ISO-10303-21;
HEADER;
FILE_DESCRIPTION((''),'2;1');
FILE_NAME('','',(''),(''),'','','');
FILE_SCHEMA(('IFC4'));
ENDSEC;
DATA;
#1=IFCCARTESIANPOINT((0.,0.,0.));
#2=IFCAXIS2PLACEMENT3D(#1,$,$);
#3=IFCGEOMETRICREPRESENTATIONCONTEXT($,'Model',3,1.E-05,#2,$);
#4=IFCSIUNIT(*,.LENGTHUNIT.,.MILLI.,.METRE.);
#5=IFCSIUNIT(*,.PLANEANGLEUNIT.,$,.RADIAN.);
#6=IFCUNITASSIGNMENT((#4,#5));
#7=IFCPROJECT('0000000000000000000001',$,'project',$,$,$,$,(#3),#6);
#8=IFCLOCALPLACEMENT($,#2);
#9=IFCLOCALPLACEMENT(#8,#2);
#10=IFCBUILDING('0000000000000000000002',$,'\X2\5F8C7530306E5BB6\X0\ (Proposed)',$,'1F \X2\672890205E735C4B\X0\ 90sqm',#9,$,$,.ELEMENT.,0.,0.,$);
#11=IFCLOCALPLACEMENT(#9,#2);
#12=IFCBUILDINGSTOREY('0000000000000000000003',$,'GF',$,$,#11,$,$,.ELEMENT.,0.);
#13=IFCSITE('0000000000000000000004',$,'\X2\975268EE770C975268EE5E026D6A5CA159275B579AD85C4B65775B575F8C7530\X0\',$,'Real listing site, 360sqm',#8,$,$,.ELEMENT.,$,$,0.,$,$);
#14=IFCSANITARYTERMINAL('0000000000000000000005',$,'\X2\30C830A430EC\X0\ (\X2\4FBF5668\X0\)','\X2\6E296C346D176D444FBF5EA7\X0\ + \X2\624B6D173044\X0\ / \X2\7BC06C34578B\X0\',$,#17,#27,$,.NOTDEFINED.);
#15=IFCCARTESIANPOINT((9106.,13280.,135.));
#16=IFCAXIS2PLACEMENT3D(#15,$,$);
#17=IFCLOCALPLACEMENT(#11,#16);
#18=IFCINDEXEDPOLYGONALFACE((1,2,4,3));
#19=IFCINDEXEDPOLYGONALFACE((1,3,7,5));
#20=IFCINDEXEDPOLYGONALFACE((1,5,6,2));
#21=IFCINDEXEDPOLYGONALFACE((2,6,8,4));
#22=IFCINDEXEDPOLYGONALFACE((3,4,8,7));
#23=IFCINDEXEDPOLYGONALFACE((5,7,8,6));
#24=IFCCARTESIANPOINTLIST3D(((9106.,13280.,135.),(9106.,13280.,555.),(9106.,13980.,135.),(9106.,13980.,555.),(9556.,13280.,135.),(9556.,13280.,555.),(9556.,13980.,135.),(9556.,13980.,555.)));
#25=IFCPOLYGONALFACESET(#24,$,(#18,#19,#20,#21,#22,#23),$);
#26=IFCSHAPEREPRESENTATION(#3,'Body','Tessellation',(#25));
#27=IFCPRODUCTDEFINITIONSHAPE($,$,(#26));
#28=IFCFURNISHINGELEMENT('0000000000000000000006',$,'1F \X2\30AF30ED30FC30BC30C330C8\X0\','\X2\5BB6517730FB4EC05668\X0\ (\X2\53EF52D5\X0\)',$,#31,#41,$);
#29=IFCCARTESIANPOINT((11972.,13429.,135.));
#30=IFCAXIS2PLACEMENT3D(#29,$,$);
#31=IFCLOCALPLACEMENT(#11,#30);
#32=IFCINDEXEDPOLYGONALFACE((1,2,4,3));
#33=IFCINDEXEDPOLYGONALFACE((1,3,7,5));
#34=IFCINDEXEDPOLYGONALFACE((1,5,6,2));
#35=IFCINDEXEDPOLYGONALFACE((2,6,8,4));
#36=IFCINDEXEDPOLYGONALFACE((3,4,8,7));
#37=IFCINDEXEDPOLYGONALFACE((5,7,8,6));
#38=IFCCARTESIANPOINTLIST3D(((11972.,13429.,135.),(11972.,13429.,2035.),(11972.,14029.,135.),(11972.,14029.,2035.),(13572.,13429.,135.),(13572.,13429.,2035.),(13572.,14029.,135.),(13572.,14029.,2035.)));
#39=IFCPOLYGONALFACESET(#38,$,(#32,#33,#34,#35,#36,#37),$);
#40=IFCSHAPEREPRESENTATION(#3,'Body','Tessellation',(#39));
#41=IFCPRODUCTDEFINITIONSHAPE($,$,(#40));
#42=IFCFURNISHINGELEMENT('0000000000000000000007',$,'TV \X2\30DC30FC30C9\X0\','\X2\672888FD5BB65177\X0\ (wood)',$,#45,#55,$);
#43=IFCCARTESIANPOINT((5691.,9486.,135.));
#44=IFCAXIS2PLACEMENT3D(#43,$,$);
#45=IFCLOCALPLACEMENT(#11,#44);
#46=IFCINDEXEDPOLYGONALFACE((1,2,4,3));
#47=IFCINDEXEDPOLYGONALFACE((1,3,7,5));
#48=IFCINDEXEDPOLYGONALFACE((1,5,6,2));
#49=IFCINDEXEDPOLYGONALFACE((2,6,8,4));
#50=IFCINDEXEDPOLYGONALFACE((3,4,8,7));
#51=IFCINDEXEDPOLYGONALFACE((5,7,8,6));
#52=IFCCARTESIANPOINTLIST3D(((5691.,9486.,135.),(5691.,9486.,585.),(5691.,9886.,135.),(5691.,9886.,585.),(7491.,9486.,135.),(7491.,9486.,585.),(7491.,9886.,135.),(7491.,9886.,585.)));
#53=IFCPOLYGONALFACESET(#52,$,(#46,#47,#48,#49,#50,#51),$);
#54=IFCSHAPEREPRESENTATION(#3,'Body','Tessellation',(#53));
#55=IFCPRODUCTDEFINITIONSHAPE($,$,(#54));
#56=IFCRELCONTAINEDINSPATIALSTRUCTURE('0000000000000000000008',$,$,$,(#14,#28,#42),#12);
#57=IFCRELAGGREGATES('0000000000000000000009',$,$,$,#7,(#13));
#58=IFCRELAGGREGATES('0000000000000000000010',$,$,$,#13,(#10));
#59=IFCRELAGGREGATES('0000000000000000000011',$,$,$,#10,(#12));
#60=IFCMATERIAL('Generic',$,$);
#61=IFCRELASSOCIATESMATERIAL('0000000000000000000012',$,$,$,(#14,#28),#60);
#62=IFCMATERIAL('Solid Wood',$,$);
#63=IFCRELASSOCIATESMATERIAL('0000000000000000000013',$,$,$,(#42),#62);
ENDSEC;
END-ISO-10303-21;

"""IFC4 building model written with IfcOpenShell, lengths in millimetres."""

from ifc_helpers import new_model, si_unit, frame, frame_2d, origin, place, context, project, spatial, rectangle, extrude, material, element, save


model = new_model("IFC4")

# Units and contexts
model_context = context("Model", 3, precision=1e-05, world=origin())
ifc_project = project(units=[si_unit("LENGTHUNIT", "METRE", prefix="MILLI"), si_unit("PLANEANGLEUNIT", "RADIAN")], contexts=[model_context])

# Site, building, storey
site_placement = place(None, origin())
site = spatial("IfcSite", under=ifc_project, at=site_placement, Name="青森県青森市浪岡大字高屋敷字後田", ObjectType="Real listing site, 360sqm", CompositionType="ELEMENT", RefElevation=0.0)
building_placement = place(site_placement, origin())
building = spatial("IfcBuilding", under=site, at=building_placement, Name="後田の家 (Proposed)", ObjectType="1F 木造平屋 90sqm", CompositionType="ELEMENT", ElevationOfRefHeight=0.0, ElevationOfTerrain=0.0)
storey_placement = place(building_placement, origin())
storey = spatial("IfcBuildingStorey", under=building, at=storey_placement, Name="GF", CompositionType="ELEMENT", Elevation=0.0)

# Shared definitions
ifc_material_1 = material(Name="Solid Wood")

# Sanitary terminal
ifc_material_2 = material(Name="Generic")
sanitary_terminal_1_placement = place(storey_placement, frame((9106.0, 13280.0, 135.0)))
element("IfcSanitaryTerminal", 1, at=sanitary_terminal_1_placement, inside=storey, material=ifc_material_2, Name="トイレ (便器)", Description="温水洗浄便座 + 手洗い / 節水型", PredefinedType="NOTDEFINED", context=model_context, shape_type="SweptSolid", body=[
    extrude(rectangle(XDim=450.0, YDim=700.0, at=frame_2d((225.0, 350.0))), frame((9106.0, 13280.0, 135.0)), (0.0, 0.0, 1.0), 420.0),
])

# Furnishing elements
furnishing_1_placement = place(storey_placement, frame((11972.0, 13429.0, 135.0)))
element("IfcFurnishingElement", 2, at=furnishing_1_placement, inside=storey, material=ifc_material_2, Name="1F クローゼット", Description="家具・什器 (可動)", context=model_context, shape_type="SweptSolid", body=[
    extrude(rectangle(XDim=1600.0, YDim=600.0, at=frame_2d((800.0, 300.0))), frame((11972.0, 13429.0, 135.0)), (0.0, 0.0, 1.0), 1900.0),
])
furnishing_2_placement = place(storey_placement, frame((5691.0, 9486.0, 135.0)))
element("IfcFurnishingElement", 3, at=furnishing_2_placement, inside=storey, material=ifc_material_1, Name="TV ボード", Description="木製家具 (wood)", context=model_context, shape_type="SweptSolid", body=[
    extrude(rectangle(XDim=1800.0, YDim=400.0, at=frame_2d((900.0, 200.0))), frame((5691.0, 9486.0, 135.0)), (0.0, 0.0, 1.0), 450.0),
])

save(model, "model.ifc")
